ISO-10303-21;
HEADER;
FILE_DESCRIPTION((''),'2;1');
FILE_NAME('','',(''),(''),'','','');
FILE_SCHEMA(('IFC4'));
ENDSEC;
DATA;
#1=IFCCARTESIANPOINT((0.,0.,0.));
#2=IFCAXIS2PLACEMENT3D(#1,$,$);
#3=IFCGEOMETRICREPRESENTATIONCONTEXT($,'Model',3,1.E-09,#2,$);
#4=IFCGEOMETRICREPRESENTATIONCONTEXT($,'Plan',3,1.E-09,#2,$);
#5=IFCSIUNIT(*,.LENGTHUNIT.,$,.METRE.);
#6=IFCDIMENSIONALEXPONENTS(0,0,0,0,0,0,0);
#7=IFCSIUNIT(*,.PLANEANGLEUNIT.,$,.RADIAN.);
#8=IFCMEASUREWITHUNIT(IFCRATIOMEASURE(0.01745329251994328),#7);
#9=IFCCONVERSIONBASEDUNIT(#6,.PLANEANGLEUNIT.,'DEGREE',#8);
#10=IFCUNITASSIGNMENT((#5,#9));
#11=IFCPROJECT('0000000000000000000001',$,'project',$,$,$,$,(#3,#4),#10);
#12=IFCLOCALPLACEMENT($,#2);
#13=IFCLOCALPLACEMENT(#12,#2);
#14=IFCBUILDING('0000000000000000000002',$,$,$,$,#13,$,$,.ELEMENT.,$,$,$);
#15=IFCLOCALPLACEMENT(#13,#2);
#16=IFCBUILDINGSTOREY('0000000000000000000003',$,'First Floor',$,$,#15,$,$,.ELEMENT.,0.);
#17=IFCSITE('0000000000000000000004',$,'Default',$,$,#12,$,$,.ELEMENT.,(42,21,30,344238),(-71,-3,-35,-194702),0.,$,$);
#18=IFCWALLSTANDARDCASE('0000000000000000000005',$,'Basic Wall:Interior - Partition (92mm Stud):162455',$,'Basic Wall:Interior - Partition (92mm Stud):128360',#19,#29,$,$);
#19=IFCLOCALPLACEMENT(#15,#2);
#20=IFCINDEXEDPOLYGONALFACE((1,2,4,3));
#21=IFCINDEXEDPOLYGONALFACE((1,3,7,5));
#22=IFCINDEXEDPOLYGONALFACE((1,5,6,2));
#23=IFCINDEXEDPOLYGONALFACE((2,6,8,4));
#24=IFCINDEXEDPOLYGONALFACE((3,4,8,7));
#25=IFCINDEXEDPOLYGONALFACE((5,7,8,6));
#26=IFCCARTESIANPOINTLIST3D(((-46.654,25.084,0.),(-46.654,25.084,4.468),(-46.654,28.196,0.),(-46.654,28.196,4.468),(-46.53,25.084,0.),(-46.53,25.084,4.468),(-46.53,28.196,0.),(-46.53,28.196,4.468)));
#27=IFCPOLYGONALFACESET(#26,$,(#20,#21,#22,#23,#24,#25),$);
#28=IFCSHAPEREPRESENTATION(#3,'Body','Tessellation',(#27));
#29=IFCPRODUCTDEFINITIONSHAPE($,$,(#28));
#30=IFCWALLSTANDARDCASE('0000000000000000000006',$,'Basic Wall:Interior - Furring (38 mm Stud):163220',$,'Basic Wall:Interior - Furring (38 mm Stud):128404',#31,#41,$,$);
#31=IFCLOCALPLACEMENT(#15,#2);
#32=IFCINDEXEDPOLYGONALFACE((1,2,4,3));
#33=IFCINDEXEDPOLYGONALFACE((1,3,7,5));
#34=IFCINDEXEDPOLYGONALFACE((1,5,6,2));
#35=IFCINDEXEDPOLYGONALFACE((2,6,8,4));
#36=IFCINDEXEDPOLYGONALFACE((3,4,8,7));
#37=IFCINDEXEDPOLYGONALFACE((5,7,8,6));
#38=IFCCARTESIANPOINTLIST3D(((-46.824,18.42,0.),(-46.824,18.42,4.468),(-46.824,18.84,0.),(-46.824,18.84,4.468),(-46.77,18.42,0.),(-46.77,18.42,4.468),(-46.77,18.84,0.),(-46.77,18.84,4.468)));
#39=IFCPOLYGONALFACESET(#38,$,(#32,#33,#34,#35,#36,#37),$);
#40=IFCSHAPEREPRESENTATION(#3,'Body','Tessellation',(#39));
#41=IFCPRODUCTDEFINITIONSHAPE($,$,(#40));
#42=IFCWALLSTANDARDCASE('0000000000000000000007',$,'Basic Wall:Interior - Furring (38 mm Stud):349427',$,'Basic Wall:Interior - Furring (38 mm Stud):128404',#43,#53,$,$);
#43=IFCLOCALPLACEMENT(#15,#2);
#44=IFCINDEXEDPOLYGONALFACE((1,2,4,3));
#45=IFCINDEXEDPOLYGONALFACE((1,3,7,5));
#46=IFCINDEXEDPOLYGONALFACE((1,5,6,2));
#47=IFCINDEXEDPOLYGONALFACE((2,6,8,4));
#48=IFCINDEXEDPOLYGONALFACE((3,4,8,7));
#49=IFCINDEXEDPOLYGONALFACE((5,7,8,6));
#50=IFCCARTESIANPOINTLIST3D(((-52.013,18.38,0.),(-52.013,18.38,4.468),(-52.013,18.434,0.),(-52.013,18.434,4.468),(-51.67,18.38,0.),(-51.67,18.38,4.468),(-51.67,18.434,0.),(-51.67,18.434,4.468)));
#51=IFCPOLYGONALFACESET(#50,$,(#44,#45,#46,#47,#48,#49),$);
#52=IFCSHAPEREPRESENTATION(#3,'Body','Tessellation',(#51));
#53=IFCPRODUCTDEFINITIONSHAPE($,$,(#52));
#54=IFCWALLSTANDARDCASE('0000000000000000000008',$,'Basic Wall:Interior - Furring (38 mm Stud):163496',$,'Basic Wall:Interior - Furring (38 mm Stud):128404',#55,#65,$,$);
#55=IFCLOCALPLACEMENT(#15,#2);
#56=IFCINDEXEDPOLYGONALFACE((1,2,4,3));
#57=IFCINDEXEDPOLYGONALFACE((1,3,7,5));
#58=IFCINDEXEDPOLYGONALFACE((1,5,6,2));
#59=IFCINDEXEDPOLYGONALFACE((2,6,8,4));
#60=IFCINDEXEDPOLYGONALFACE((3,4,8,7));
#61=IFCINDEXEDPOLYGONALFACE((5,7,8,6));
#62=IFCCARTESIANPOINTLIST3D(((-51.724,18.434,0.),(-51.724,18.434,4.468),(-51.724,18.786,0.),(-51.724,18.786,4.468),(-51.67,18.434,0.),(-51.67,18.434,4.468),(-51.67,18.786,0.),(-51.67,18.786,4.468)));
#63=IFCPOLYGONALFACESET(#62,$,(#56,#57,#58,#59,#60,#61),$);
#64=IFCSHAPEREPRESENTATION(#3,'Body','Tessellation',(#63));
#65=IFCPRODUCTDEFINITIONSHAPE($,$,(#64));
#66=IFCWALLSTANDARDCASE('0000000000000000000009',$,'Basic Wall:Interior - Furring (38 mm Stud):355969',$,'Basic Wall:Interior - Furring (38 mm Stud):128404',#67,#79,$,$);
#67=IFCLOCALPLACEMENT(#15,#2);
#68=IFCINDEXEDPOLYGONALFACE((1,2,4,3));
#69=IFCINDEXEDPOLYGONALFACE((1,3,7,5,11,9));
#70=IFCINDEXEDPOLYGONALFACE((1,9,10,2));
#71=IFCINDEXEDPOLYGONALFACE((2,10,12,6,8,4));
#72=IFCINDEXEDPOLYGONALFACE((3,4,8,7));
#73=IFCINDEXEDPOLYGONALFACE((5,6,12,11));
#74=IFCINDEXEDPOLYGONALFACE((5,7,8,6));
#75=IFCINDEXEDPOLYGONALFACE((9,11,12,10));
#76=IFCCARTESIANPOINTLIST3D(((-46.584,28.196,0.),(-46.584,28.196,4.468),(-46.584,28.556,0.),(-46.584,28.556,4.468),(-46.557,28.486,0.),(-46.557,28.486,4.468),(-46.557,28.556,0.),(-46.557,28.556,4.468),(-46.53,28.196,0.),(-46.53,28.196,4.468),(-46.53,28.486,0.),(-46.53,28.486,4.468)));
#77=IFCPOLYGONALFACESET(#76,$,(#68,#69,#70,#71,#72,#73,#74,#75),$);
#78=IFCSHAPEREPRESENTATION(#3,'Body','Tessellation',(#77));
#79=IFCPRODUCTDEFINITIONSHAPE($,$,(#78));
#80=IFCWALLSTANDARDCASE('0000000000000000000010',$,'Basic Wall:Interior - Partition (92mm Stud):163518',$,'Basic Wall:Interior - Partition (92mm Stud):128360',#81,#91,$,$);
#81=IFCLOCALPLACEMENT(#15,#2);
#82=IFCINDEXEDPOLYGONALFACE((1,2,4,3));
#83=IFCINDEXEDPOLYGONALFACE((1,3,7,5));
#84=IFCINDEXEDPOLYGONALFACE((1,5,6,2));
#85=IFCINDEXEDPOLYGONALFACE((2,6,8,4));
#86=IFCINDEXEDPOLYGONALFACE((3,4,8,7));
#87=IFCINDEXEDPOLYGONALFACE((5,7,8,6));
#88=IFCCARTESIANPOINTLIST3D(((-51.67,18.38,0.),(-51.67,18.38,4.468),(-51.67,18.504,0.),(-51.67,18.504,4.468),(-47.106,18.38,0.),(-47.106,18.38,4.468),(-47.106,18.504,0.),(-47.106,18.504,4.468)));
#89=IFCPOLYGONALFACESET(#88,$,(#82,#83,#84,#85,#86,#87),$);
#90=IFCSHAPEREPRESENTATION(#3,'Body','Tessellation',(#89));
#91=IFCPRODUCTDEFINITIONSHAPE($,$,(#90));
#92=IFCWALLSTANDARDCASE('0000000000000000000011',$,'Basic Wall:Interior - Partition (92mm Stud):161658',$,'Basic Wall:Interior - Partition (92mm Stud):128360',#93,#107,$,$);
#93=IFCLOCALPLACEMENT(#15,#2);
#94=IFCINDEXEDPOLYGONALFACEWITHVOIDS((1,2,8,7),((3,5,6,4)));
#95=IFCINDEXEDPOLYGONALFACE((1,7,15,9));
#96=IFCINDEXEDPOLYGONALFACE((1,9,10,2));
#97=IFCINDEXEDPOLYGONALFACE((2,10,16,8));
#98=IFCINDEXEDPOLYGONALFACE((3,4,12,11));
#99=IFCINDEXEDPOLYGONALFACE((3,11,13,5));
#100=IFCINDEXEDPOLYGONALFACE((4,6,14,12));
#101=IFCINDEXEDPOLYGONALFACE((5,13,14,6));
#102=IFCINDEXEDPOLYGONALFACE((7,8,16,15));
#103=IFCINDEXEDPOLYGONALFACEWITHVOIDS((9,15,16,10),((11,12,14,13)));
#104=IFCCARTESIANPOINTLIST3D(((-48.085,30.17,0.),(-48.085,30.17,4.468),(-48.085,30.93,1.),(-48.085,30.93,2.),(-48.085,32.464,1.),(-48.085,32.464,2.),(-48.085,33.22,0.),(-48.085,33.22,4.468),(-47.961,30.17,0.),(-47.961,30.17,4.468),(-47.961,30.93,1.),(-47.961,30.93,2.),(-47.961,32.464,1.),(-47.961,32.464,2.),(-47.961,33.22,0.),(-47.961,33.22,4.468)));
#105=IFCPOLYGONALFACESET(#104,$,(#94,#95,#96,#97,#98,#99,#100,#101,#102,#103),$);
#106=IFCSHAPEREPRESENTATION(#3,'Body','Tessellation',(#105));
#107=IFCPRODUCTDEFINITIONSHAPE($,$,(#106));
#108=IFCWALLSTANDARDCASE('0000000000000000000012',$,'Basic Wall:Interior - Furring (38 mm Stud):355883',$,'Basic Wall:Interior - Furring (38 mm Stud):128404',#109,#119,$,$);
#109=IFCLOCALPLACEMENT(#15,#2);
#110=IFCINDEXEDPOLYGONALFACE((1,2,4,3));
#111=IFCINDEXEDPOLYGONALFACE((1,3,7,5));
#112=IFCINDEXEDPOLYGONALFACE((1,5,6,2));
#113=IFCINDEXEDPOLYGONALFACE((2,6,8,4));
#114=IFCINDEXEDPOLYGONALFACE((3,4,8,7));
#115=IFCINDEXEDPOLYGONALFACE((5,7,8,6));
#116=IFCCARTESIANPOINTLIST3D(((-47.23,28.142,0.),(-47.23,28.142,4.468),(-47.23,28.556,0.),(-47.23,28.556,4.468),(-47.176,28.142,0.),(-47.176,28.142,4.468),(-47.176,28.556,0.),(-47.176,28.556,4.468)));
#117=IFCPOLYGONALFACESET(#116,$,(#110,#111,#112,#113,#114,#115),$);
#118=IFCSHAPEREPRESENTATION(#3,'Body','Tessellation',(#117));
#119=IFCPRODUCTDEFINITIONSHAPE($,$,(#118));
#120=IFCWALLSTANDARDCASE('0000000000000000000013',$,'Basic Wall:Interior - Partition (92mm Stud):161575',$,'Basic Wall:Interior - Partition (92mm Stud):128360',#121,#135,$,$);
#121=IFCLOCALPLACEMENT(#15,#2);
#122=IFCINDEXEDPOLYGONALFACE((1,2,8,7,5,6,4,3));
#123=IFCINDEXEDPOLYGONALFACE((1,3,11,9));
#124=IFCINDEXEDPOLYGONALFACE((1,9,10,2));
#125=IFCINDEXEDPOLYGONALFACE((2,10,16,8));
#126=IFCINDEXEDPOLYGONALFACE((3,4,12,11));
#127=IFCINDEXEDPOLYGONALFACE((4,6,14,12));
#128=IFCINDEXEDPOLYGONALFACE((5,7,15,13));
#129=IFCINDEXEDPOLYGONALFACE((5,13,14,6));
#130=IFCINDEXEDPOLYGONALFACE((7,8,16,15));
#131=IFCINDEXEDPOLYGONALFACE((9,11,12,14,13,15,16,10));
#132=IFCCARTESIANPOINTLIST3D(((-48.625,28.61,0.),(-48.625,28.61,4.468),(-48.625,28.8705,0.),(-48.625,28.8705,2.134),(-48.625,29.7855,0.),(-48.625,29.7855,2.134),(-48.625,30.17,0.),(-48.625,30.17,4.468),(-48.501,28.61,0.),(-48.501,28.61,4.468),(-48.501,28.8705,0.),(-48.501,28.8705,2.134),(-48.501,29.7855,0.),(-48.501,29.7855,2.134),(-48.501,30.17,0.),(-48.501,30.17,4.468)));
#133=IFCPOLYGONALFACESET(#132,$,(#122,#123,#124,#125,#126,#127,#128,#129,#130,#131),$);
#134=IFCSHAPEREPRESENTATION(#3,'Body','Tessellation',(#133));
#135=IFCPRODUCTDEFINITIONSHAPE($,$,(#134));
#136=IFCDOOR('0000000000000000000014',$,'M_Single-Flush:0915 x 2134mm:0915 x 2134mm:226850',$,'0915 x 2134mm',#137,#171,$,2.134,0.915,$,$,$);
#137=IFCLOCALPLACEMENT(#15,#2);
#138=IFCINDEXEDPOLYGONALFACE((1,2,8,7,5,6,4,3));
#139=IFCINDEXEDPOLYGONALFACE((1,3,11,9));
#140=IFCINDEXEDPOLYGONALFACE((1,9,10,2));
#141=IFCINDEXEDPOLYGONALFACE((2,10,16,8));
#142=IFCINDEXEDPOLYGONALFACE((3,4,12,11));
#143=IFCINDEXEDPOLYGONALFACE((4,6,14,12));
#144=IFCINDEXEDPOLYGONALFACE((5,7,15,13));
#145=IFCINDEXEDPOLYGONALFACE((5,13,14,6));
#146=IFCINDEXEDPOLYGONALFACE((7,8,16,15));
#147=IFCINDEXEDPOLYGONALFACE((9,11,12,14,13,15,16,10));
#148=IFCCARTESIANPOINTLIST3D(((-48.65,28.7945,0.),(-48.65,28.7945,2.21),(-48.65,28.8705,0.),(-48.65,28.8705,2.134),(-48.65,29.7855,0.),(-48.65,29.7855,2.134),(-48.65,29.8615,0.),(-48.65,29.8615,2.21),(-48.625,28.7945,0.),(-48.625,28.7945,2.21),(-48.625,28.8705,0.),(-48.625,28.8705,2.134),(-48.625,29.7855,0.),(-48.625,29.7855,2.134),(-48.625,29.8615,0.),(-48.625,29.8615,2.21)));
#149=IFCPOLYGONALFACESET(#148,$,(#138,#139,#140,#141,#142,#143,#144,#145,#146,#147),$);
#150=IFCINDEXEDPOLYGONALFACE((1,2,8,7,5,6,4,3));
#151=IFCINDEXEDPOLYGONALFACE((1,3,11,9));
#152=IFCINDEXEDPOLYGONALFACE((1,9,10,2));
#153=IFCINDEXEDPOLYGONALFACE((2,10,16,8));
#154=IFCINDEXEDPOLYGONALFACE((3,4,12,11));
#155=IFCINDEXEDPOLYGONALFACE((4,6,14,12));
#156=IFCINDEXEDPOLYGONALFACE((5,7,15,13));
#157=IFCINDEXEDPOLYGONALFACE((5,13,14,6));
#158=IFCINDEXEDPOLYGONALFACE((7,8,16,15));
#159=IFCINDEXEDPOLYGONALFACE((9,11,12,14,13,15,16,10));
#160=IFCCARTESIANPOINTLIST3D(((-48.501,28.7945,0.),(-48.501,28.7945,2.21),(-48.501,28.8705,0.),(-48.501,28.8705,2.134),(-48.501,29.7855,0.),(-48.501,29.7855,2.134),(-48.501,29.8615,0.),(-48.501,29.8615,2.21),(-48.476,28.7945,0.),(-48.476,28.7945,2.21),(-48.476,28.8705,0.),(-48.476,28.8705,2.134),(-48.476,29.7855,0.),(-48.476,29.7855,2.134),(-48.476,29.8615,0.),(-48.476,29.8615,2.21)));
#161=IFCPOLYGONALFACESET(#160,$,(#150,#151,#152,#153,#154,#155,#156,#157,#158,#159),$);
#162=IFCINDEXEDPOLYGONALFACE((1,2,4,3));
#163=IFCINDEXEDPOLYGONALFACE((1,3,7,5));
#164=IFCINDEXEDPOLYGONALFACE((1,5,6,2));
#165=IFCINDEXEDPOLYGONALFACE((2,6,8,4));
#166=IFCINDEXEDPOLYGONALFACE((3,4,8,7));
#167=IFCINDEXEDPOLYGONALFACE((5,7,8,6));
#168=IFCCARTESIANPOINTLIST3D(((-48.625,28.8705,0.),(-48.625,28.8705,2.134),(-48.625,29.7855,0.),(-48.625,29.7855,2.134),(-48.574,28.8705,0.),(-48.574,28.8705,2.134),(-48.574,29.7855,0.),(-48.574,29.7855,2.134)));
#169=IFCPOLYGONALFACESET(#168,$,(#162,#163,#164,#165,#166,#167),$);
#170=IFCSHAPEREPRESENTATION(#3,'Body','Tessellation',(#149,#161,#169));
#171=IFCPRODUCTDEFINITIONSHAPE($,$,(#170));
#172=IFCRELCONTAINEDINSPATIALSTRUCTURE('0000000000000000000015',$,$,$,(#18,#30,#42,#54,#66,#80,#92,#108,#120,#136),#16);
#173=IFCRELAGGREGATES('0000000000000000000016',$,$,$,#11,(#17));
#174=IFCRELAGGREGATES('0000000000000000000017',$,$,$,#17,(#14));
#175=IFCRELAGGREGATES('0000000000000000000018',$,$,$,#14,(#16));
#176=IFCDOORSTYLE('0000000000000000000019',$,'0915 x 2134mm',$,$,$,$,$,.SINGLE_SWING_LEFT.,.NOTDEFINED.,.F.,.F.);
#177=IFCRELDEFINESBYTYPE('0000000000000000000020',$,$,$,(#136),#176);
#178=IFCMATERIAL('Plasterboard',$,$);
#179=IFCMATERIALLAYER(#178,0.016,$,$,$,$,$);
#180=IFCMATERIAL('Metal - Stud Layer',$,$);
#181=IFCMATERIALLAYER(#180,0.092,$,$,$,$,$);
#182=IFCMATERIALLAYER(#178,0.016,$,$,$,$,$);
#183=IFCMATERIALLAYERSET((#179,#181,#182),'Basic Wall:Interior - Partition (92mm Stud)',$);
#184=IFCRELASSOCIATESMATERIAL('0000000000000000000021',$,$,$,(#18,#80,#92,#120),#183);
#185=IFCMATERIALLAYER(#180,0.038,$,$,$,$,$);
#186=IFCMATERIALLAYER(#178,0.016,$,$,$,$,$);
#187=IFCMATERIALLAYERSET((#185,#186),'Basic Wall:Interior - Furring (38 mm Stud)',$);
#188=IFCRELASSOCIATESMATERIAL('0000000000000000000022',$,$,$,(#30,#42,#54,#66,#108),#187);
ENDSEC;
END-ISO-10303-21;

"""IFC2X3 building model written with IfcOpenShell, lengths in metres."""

from ifc_helpers import new_model, entity, si_unit, converted_unit, frame, frame_2d, origin, origin_2d_with_axis, place, context, project, spatial, polyline, rectangle, outline, extrude, source, transform, mapped, material, layer, layer_set, layer_usage, type_object, type_shapes, element, fill, save


model = new_model("IFC2X3")

# Units and contexts
model_context = context("Model", 3, precision=1e-09, world=origin())
plan_context = context("Plan", 3, precision=1e-09, world=origin())
ifc_project = project(units=[si_unit("LENGTHUNIT", "METRE"), converted_unit("PLANEANGLEUNIT", "DEGREE", entity("IfcRatioMeasure", 0.01745329251994328), si_unit("PLANEANGLEUNIT", "RADIAN"), dimensions=[0, 0, 0, 0, 0, 0, 0])], contexts=[model_context, plan_context])

# Site, building, storey
site_placement = place(None, origin())
site = spatial("IfcSite", under=ifc_project, at=site_placement, Name="Default", CompositionType="ELEMENT", RefLatitude=(42, 21, 30, 344238), RefLongitude=(-71, -3, -35, -194702), RefElevation=0.0)
building_placement = place(site_placement, origin())
building = spatial("IfcBuilding", under=site, at=building_placement, CompositionType="ELEMENT")
storey_placement = place(building_placement, origin())
storey = spatial("IfcBuildingStorey", under=building, at=storey_placement, Name="First Floor", CompositionType="ELEMENT", Elevation=0.0)

# Shared definitions
ifc_material_1 = material(Name="Plasterboard")
ifc_layer_1 = layer(ifc_material_1, 0.016)
ifc_material_2 = material(Name="Metal - Stud Layer")
ifc_layer_2 = layer(ifc_material_2, 0.092)
ifc_layer_3 = layer(ifc_material_1, 0.016)
ifc_layer_set_1 = layer_set([ifc_layer_1, ifc_layer_2, ifc_layer_3], Name="Basic Wall:Interior - Partition (92mm Stud)")
ifc_layer_usage_1 = layer_usage(ifc_layer_set_1, "AXIS2", "NEGATIVE", 0.062)
door_style = type_object("IfcDoorStyle", Name="0915 x 2134mm", ConstructionType="NOTDEFINED", OperationType="SINGLE_SWING_LEFT", ParameterTakesPrecedence=False, Sizeable=False)
shared_shape_1 = source(origin(), model_context, "Body", "SweptSolid", [
    extrude(outline(polyline([(-0.5335, -1.124), (0.5335, -1.124), (0.5335, 1.086), (0.4575, 1.086), (0.4575, -1.048), (-0.4575, -1.048), (-0.4575, 1.086), (-0.5335, 1.086), (-0.5335, -1.124)])), frame((0.4575, 0.149, 1.086), z_axis=(0.0, -1.0, 0.0), x_axis=(-1.0, 0.0, 0.0)), (0.0, 0.0, 1.0), 0.025),
    extrude(outline(polyline([(-1.124, -0.5335), (1.086, -0.5335), (1.086, -0.4575), (-1.048, -0.4575), (-1.048, 0.4575), (1.086, 0.4575), (1.086, 0.5335), (-1.124, 0.5335), (-1.124, -0.5335)])), frame((0.4575, 0.0, 1.086), z_axis=(0.0, -1.0, 0.0), x_axis=(0.0, 0.0, -1.0)), (0.0, 0.0, 1.0), 0.025),
    extrude(rectangle(XDim=0.915, YDim=0.051, at=origin_2d_with_axis()), frame((0.4575, 0.0985, 0.0)), (0.0, 0.0, 1.0), 2.134),
])
type_shapes(door_style, [shared_shape_1])

# Walls
wall_1_placement = place(storey_placement, frame((-46.592, 28.196, 0.0), z_axis=(0.0, 0.0, 1.0), x_axis=(0.0, -1.0, 0.0)))
element("IfcWallStandardCase", 1, at=wall_1_placement, inside=storey, material=ifc_layer_usage_1, Name="Basic Wall:Interior - Partition (92mm Stud):162455", ObjectType="Basic Wall:Interior - Partition (92mm Stud):128360", context=model_context, shape_type="SweptSolid", body=[
    extrude(rectangle(XDim=3.112, YDim=0.124, at=frame_2d((1.556, 0.0), x_axis=(-1.0, 0.0))), origin(), (0.0, 0.0, 1.0), 4.468),
])
ifc_layer_4 = layer(ifc_material_2, 0.038)
ifc_layer_5 = layer(ifc_material_1, 0.016)
ifc_layer_set_2 = layer_set([ifc_layer_4, ifc_layer_5], Name="Basic Wall:Interior - Furring (38 mm Stud)")
ifc_layer_usage_2 = layer_usage(ifc_layer_set_2, "AXIS2", "POSITIVE", -0.027)
wall_2_placement = place(storey_placement, frame((-46.797, 18.84, 0.0), z_axis=(0.0, 0.0, 1.0), x_axis=(0.0, -1.0, 0.0)))
element("IfcWallStandardCase", 2, at=wall_2_placement, inside=storey, material=ifc_layer_usage_2, Name="Basic Wall:Interior - Furring (38 mm Stud):163220", ObjectType="Basic Wall:Interior - Furring (38 mm Stud):128404", context=model_context, shape_type="SweptSolid", body=[
    extrude(rectangle(XDim=0.42, YDim=0.054, at=frame_2d((0.21, 0.0), x_axis=(-1.0, 0.0))), origin(), (0.0, 0.0, 1.0), 4.468),
])
wall_3_placement = place(storey_placement, frame((-51.67, 18.407, 0.0), z_axis=(0.0, 0.0, 1.0), x_axis=(-1.0, 0.0, 0.0)))
element("IfcWallStandardCase", 3, at=wall_3_placement, inside=storey, material=ifc_layer_usage_2, Name="Basic Wall:Interior - Furring (38 mm Stud):349427", ObjectType="Basic Wall:Interior - Furring (38 mm Stud):128404", context=model_context, shape_type="SweptSolid", body=[
    extrude(rectangle(XDim=0.343, YDim=0.054, at=frame_2d((0.1715, 0.0), x_axis=(-1.0, 0.0))), origin(), (0.0, 0.0, 1.0), 4.468),
])
wall_4_placement = place(storey_placement, frame((-51.697, 18.786, 0.0), z_axis=(0.0, 0.0, 1.0), x_axis=(0.0, -1.0, 0.0)))
element("IfcWallStandardCase", 4, at=wall_4_placement, inside=storey, material=ifc_layer_usage_2, Name="Basic Wall:Interior - Furring (38 mm Stud):163496", ObjectType="Basic Wall:Interior - Furring (38 mm Stud):128404", context=model_context, shape_type="SweptSolid", body=[
    extrude(rectangle(XDim=0.352, YDim=0.054, at=frame_2d((0.176, 0.0), x_axis=(-1.0, 0.0))), origin(), (0.0, 0.0, 1.0), 4.468),
])
ifc_layer_usage_3 = layer_usage(ifc_layer_set_2, "AXIS2", "NEGATIVE", 0.027)
wall_5_placement = place(storey_placement, frame((-46.557, 28.196, 0.0), z_axis=(0.0, 0.0, 1.0), x_axis=(0.0, 1.0, 0.0)))
element("IfcWallStandardCase", 5, at=wall_5_placement, inside=storey, material=ifc_layer_usage_3, Name="Basic Wall:Interior - Furring (38 mm Stud):355969", ObjectType="Basic Wall:Interior - Furring (38 mm Stud):128404", context=model_context, shape_type="SweptSolid", body=[
    extrude(outline(polyline([(0.29, -0.027), (0.29, 0.0), (0.36, 0.0), (0.36, 0.027), (0.0, 0.027), (0.0, -0.027), (0.29, -0.027)])), origin(), (0.0, 0.0, 1.0), 4.468),
])
wall_6_placement = place(storey_placement, frame((-47.106, 18.442, 0.0), z_axis=(0.0, 0.0, 1.0), x_axis=(-1.0, 0.0, 0.0)))
element("IfcWallStandardCase", 6, at=wall_6_placement, inside=storey, material=ifc_layer_usage_1, Name="Basic Wall:Interior - Partition (92mm Stud):163518", ObjectType="Basic Wall:Interior - Partition (92mm Stud):128360", context=model_context, shape_type="SweptSolid", body=[
    extrude(rectangle(XDim=4.564, YDim=0.124, at=frame_2d((2.282, 0.0), x_axis=(-1.0, 0.0))), origin(), (0.0, 0.0, 1.0), 4.468),
])

# Wall, opening
wall_7_placement = place(storey_placement, frame((-48.023, 30.17, 0.0), z_axis=(0.0, 0.0, 1.0), x_axis=(0.0, 1.0, 0.0)))
wall_7 = element("IfcWallStandardCase", 7, at=wall_7_placement, inside=storey, material=ifc_layer_usage_1, Name="Basic Wall:Interior - Partition (92mm Stud):161658", ObjectType="Basic Wall:Interior - Partition (92mm Stud):128360", context=model_context, shape_type="SweptSolid", body=[
    extrude(rectangle(XDim=3.05, YDim=0.124, at=frame_2d((1.525, 0.0), x_axis=(-1.0, 0.0))), origin(), (0.0, 0.0, 1.0), 4.468),
])
opening_1_placement = place(wall_7_placement, origin())
element("IfcOpeningElement", 8, at=opening_1_placement, cuts=wall_7, ObjectType="Opening", context=model_context, shape_type="SweptSolid", body=[
    extrude(rectangle(XDim=1.0, YDim=1.534, at=frame_2d((0.0, 0.0), x_axis=(0.0, 1.0))), frame((1.527, -0.2144, 1.5), z_axis=(0.0, 1.0, 0.0), x_axis=(-1.0, 0.0, 0.0)), (0.0, 0.0, 1.0), 0.4288),
])

# Wall
wall_8_placement = place(storey_placement, frame((-47.203, 28.556, 0.0), z_axis=(0.0, 0.0, 1.0), x_axis=(0.0, -1.0, 0.0)))
element("IfcWallStandardCase", 9, at=wall_8_placement, inside=storey, material=ifc_layer_usage_3, Name="Basic Wall:Interior - Furring (38 mm Stud):355883", ObjectType="Basic Wall:Interior - Furring (38 mm Stud):128404", context=model_context, shape_type="SweptSolid", body=[
    extrude(rectangle(XDim=0.414, YDim=0.054, at=frame_2d((0.207, 0.0), x_axis=(-1.0, 0.0))), origin(), (0.0, 0.0, 1.0), 4.468),
])

# Wall, opening, door
wall_9_placement = place(storey_placement, frame((-48.563, 28.61, 0.0), z_axis=(0.0, 0.0, 1.0), x_axis=(0.0, 1.0, 0.0)))
wall_9 = element("IfcWallStandardCase", 10, at=wall_9_placement, inside=storey, material=ifc_layer_usage_1, Name="Basic Wall:Interior - Partition (92mm Stud):161575", ObjectType="Basic Wall:Interior - Partition (92mm Stud):128360", context=model_context, shape_type="SweptSolid", body=[
    extrude(rectangle(XDim=1.56, YDim=0.124, at=frame_2d((0.78, 0.0), x_axis=(-1.0, 0.0))), origin(), (0.0, 0.0, 1.0), 4.468),
])
opening_2_placement = place(wall_9_placement, frame((0.2605, -0.062, 0.0)))
opening_2 = element("IfcOpeningElement", 11, at=opening_2_placement, cuts=wall_9, ObjectType="Opening", context=model_context, shape_type="SweptSolid", body=[
    extrude(rectangle(XDim=0.915, YDim=2.134, at=frame_2d((1.067, 0.4575), x_axis=(0.0, -1.0))), frame((0.0, 0.0, 0.0), z_axis=(0.0, 1.0, 0.0), x_axis=(0.0, 0.0, 1.0)), (0.0, 0.0, 1.0), 0.124),
])
door_1_placement = place(opening_2_placement, origin())
door_1 = element("IfcDoor", 12, at=door_1_placement, inside=storey, type_object=door_style, Name="M_Single-Flush:0915 x 2134mm:0915 x 2134mm:226850", ObjectType="0915 x 2134mm", OverallHeight=2.134, OverallWidth=0.915, context=model_context, shape_type="MappedRepresentation", body=[
    mapped(shared_shape_1, transform((0.0, 0.0, 0.0), scale=1.0)),
])
fill(opening_2, door_1)

save(model, "model.ifc")
